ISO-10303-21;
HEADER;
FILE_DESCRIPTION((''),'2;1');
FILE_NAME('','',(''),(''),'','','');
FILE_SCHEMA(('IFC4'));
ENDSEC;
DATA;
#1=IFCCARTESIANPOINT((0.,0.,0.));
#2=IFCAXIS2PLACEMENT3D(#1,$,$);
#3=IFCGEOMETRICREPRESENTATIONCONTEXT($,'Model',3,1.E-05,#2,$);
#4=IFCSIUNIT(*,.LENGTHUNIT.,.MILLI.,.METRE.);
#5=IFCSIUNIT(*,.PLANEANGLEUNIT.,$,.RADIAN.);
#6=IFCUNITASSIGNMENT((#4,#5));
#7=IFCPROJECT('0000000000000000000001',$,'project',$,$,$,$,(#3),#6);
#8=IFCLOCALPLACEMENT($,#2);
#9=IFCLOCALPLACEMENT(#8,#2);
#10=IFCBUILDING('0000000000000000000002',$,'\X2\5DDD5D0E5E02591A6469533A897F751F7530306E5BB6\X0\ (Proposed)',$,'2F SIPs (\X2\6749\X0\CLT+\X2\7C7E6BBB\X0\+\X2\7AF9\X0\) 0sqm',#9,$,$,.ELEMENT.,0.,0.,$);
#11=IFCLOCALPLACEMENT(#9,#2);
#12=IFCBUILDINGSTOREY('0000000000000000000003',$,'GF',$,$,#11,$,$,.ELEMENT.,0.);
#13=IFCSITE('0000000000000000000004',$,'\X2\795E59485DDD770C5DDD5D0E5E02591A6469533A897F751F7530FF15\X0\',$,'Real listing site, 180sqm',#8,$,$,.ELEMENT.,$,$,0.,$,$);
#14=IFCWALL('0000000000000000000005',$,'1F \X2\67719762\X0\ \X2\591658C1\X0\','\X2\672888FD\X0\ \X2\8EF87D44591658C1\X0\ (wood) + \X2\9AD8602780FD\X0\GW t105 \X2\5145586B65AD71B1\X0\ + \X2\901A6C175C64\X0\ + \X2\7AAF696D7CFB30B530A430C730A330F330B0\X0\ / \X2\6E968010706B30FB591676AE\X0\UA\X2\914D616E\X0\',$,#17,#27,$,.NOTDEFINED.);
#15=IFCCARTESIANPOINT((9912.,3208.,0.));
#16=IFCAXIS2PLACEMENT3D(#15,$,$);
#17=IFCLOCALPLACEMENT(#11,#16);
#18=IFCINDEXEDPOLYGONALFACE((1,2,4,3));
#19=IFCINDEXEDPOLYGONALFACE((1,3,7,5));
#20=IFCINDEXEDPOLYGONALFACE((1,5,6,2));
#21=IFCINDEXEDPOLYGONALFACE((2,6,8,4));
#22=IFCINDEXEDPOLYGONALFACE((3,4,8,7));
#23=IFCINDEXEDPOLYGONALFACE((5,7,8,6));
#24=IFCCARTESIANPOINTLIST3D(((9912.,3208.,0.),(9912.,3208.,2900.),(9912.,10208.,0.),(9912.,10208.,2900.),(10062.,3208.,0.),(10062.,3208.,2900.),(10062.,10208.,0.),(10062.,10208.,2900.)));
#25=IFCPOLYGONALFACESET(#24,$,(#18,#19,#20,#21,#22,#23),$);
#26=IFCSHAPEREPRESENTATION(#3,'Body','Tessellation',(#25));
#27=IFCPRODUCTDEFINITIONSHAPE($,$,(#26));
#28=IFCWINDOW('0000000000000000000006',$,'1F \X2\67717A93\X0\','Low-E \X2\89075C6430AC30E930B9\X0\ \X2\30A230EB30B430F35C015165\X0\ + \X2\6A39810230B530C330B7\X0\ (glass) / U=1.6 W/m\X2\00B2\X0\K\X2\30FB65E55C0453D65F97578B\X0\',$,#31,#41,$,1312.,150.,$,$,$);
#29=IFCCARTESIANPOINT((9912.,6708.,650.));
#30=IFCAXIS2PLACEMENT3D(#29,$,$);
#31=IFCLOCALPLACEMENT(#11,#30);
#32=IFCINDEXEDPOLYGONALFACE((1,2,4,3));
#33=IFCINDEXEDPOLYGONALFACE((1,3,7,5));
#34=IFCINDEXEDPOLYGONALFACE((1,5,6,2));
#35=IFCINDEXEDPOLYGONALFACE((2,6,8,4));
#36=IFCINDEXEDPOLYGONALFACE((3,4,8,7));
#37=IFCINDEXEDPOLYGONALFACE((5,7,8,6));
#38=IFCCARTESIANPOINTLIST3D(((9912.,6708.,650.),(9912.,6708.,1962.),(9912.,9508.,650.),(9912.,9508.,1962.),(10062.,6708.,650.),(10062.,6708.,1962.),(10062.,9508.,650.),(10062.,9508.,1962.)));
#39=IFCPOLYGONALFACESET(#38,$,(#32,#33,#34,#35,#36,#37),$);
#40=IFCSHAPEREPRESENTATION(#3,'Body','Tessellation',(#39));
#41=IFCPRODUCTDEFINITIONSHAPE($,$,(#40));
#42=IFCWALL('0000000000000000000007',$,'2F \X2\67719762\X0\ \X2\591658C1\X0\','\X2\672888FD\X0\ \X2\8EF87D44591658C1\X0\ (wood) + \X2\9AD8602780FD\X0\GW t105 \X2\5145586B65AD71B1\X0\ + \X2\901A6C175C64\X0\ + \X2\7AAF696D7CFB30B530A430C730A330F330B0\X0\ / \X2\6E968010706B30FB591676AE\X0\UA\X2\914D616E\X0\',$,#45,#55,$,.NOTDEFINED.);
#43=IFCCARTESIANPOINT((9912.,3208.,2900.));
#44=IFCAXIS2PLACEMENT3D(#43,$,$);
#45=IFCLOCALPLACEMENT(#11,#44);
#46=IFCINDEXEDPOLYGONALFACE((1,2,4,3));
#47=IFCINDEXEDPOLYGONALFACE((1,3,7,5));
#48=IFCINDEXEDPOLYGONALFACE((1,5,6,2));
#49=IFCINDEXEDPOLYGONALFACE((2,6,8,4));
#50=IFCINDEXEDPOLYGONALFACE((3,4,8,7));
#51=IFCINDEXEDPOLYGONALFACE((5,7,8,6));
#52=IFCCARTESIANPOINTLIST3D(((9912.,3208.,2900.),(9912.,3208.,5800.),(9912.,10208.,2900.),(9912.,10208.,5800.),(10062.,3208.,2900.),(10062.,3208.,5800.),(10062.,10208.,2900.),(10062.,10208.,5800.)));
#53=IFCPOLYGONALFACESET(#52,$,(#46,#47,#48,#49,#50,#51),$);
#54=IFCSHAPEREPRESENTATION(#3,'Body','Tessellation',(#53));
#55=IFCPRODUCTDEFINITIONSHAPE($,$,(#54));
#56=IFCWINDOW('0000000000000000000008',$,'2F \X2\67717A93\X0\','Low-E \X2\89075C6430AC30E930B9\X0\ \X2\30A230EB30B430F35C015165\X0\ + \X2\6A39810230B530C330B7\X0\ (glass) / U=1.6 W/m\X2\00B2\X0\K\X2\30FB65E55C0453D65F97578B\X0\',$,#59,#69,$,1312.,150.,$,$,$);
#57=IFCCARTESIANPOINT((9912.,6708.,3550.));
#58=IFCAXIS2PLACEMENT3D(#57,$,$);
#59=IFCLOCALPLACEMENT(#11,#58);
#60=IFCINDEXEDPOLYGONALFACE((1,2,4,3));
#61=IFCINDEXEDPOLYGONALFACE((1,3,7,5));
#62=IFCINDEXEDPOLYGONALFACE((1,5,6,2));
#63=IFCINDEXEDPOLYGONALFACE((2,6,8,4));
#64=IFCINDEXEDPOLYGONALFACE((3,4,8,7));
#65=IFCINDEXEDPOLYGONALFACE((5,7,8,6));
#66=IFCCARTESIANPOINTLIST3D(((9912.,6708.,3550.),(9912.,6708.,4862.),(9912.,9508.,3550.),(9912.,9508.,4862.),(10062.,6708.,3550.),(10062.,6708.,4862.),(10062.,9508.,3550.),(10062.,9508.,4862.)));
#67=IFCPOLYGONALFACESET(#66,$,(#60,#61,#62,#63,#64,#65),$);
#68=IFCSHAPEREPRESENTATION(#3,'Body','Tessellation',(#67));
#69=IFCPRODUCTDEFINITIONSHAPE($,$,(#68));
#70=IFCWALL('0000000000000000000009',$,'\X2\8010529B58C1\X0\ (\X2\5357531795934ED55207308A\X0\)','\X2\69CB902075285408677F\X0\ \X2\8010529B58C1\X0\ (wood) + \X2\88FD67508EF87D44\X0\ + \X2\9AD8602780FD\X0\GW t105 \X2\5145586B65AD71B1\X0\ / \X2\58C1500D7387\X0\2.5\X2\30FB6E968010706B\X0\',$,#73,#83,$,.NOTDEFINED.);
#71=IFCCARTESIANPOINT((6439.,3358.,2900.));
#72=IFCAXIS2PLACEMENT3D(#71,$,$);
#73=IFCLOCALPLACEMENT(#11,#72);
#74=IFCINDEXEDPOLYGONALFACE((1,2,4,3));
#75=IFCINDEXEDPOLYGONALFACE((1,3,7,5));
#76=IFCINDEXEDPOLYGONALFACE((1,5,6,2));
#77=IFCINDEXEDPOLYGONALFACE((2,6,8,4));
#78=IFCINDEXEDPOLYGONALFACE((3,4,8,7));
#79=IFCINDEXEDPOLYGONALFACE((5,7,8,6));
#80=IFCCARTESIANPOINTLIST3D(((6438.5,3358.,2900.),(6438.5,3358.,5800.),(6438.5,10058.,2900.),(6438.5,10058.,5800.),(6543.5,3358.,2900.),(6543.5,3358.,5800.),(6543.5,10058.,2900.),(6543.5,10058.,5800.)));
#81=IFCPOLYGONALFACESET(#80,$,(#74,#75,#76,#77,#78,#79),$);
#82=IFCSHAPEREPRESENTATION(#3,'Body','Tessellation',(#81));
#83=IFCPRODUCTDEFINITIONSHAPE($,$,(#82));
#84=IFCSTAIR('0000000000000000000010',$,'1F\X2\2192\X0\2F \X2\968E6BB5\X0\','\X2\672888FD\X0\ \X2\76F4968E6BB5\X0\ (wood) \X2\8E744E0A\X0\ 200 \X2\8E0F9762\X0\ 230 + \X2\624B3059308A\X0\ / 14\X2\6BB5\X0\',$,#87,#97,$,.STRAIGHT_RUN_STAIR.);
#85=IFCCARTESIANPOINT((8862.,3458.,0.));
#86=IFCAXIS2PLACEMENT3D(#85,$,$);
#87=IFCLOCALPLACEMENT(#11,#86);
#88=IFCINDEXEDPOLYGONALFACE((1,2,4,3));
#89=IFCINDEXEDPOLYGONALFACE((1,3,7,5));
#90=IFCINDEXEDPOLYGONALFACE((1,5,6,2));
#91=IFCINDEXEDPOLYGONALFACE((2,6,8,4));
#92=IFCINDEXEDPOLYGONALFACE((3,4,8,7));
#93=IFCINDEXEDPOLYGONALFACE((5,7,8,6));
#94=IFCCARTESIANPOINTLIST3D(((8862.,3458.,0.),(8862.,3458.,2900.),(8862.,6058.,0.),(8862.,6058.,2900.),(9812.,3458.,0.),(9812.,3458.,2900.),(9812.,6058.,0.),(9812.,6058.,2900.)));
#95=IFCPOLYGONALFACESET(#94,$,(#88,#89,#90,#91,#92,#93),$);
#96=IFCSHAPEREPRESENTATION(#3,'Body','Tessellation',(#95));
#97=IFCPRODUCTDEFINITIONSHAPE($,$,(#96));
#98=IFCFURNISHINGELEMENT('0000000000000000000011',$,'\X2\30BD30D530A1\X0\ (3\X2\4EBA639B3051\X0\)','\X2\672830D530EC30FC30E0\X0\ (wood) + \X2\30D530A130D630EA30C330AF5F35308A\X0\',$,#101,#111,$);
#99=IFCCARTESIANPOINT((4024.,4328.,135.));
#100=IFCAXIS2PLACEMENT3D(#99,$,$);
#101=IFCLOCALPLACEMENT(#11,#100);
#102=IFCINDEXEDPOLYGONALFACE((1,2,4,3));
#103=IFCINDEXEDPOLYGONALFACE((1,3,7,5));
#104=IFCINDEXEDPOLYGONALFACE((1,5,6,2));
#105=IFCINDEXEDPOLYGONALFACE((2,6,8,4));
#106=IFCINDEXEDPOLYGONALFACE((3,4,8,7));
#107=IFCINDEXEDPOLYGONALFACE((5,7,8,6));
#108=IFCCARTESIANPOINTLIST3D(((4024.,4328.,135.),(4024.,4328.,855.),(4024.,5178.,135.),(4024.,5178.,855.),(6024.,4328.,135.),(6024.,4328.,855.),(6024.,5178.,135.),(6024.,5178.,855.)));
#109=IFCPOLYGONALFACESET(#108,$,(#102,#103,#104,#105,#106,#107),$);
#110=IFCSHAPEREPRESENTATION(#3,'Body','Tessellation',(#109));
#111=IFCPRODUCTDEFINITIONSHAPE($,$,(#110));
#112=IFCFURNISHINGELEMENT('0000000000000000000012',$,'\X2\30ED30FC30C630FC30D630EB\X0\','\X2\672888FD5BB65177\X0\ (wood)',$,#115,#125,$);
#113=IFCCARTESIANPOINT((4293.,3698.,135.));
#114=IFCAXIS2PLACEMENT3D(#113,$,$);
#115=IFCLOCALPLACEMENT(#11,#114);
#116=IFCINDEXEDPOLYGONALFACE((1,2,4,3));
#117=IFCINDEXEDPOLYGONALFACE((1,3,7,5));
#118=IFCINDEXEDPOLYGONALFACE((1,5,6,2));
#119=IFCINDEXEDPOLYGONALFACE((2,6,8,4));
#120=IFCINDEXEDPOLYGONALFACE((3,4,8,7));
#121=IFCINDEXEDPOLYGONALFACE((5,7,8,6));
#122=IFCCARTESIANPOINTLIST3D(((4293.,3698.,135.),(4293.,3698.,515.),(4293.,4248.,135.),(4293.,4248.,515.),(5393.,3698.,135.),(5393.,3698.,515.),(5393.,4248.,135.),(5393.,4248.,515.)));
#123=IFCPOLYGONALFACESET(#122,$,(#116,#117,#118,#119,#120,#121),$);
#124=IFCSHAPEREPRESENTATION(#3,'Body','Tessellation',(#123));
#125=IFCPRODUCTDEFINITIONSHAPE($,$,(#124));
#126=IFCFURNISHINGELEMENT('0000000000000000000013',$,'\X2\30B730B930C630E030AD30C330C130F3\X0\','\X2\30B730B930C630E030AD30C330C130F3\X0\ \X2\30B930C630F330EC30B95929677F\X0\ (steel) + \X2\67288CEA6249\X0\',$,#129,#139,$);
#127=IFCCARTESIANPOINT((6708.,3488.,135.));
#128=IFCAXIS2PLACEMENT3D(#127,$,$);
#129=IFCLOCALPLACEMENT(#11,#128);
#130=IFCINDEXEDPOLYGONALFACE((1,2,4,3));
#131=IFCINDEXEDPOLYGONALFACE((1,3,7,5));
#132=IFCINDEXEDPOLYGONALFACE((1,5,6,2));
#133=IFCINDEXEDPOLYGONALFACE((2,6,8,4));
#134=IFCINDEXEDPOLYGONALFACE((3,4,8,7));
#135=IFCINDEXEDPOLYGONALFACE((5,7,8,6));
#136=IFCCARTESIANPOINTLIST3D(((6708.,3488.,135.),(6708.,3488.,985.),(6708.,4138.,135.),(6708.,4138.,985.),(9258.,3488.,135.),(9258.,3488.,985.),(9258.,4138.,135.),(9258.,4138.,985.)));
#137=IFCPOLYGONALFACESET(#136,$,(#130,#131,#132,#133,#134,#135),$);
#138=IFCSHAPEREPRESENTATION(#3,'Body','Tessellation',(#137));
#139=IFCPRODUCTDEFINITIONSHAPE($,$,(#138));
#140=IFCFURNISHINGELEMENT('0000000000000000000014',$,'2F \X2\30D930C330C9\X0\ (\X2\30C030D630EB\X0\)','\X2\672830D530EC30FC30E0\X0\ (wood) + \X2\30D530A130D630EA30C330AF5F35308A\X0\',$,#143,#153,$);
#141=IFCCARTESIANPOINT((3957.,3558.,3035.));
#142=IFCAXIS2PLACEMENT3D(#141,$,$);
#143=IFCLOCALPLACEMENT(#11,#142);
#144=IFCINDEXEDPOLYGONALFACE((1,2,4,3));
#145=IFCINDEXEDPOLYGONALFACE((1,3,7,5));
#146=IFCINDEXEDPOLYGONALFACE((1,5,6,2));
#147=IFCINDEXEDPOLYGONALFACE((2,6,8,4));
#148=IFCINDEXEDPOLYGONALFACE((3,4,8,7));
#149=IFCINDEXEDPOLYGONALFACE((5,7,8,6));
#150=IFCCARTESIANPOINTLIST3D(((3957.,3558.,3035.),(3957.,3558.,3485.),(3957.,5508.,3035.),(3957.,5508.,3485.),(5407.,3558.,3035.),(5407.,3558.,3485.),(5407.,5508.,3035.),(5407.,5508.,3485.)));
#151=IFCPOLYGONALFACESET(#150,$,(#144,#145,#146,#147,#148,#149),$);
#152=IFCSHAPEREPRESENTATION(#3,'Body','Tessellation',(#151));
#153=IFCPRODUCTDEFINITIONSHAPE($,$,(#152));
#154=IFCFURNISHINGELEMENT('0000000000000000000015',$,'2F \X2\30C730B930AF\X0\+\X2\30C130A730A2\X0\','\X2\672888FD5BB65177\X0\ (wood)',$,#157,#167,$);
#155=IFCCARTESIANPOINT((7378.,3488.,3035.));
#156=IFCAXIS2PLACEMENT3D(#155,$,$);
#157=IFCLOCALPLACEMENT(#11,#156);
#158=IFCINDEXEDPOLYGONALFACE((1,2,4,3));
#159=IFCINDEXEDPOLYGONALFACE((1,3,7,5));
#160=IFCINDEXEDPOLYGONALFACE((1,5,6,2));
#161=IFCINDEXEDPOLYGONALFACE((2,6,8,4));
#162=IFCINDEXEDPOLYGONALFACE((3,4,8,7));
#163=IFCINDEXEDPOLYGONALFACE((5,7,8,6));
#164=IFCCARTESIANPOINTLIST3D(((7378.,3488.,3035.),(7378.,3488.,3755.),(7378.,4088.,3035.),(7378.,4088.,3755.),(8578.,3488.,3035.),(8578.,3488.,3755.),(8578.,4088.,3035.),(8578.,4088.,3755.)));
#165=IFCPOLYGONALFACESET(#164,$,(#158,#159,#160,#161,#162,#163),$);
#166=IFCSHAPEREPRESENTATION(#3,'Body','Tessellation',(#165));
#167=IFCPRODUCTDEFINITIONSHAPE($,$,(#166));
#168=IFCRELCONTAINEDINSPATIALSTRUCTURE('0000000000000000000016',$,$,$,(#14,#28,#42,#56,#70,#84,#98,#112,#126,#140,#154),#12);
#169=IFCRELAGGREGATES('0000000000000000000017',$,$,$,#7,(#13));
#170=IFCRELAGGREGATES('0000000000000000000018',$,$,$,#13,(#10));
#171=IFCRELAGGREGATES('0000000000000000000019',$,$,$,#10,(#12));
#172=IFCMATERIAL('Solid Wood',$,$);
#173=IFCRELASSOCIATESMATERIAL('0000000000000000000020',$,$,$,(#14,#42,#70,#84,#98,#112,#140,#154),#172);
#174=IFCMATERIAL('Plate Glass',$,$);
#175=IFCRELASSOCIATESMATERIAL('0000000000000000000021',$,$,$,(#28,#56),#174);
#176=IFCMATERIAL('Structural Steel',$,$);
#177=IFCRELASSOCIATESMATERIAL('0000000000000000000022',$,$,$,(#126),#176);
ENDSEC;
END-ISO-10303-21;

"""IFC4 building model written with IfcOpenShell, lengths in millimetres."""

from ifc_helpers import new_model, si_unit, frame, frame_2d, origin, place, context, project, spatial, rectangle, extrude, material, element, fill, save


model = new_model("IFC4")

# Units and contexts
model_context = context("Model", 3, precision=1e-05, world=origin())
ifc_project = project(units=[si_unit("LENGTHUNIT", "METRE", prefix="MILLI"), si_unit("PLANEANGLEUNIT", "RADIAN")], contexts=[model_context])

# Site, building, storey
site_placement = place(None, origin())
site = spatial("IfcSite", under=ifc_project, at=site_placement, Name="神奈川県川崎市多摩区西生田５", ObjectType="Real listing site, 180sqm", CompositionType="ELEMENT", RefElevation=0.0)
building_placement = place(site_placement, origin())
building = spatial("IfcBuilding", under=site, at=building_placement, Name="川崎市多摩区西生田の家 (Proposed)", ObjectType="2F SIPs (杉CLT+籾殻+竹) 0sqm", CompositionType="ELEMENT", ElevationOfRefHeight=0.0, ElevationOfTerrain=0.0)
storey_placement = place(building_placement, origin())
storey = spatial("IfcBuildingStorey", under=building, at=storey_placement, Name="GF", CompositionType="ELEMENT", Elevation=0.0)

# Wall, opening, window
ifc_material_1 = material(Name="Solid Wood")
wall_1_placement = place(storey_placement, frame((9912.0, 3208.0, 0.0)))
wall_1 = element("IfcWall", 1, at=wall_1_placement, inside=storey, material=ifc_material_1, Name="1F 東面 外壁", Description="木製 軸組外壁 (wood) + 高性能GW t105 充填断熱 + 通気層 + 窯業系サイディング / 準耐火・外皮UA配慮", PredefinedType="NOTDEFINED", context=model_context, shape_type="SweptSolid", body=[
    extrude(rectangle(XDim=150.0, YDim=7000.0, at=frame_2d((75.0, 3500.0))), frame((9912.0, 3208.0, 0.0)), (0.0, 0.0, 1.0), 2900.0),
])
opening_1_placement = place(storey_placement, frame((9912.0, 6708.0, 650.0)))
opening_1 = element("IfcOpeningElement", 2, at=opening_1_placement, cuts=wall_1, PredefinedType="NOTDEFINED", context=model_context, shape_type="SweptSolid", body=[
    extrude(rectangle(XDim=150.0, YDim=2800.0, at=frame_2d((75.0, 1400.0))), frame((9912.0, 6708.0, 650.0)), (0.0, 0.0, 1.0), 1312.0),
])
ifc_material_2 = material(Name="Plate Glass")
window_1_placement = place(storey_placement, frame((9912.0, 6708.0, 650.0)))
window_1 = element("IfcWindow", 3, at=window_1_placement, inside=storey, material=ifc_material_2, Name="1F 東窓", Description="Low-E 複層ガラス アルゴン封入 + 樹脂サッシ (glass) / U=1.6 W/m²K・日射取得型", OverallHeight=1312.0, OverallWidth=150.0, context=model_context, shape_type="SweptSolid", body=[
    extrude(rectangle(XDim=150.0, YDim=2800.0, at=frame_2d((75.0, 1400.0))), frame((9912.0, 6708.0, 650.0)), (0.0, 0.0, 1.0), 1312.0),
])
fill(opening_1, window_1)

# Wall, opening, window
wall_2_placement = place(storey_placement, frame((9912.0, 3208.0, 2900.0)))
wall_2 = element("IfcWall", 4, at=wall_2_placement, inside=storey, material=ifc_material_1, Name="2F 東面 外壁", Description="木製 軸組外壁 (wood) + 高性能GW t105 充填断熱 + 通気層 + 窯業系サイディング / 準耐火・外皮UA配慮", PredefinedType="NOTDEFINED", context=model_context, shape_type="SweptSolid", body=[
    extrude(rectangle(XDim=150.0, YDim=7000.0, at=frame_2d((75.0, 3500.0))), frame((9912.0, 3208.0, 2900.0)), (0.0, 0.0, 1.0), 2900.0),
])
opening_2_placement = place(storey_placement, frame((9912.0, 6708.0, 3550.0)))
opening_2 = element("IfcOpeningElement", 5, at=opening_2_placement, cuts=wall_2, PredefinedType="NOTDEFINED", context=model_context, shape_type="SweptSolid", body=[
    extrude(rectangle(XDim=150.0, YDim=2800.0, at=frame_2d((75.0, 1400.0))), frame((9912.0, 6708.0, 3550.0)), (0.0, 0.0, 1.0), 1312.0),
])
window_2_placement = place(storey_placement, frame((9912.0, 6708.0, 3550.0)))
window_2 = element("IfcWindow", 6, at=window_2_placement, inside=storey, material=ifc_material_2, Name="2F 東窓", Description="Low-E 複層ガラス アルゴン封入 + 樹脂サッシ (glass) / U=1.6 W/m²K・日射取得型", OverallHeight=1312.0, OverallWidth=150.0, context=model_context, shape_type="SweptSolid", body=[
    extrude(rectangle(XDim=150.0, YDim=2800.0, at=frame_2d((75.0, 1400.0))), frame((9912.0, 6708.0, 3550.0)), (0.0, 0.0, 1.0), 1312.0),
])
fill(opening_2, window_2)

# Wall
wall_3_placement = place(storey_placement, frame((6439.0, 3358.0, 2900.0)))
element("IfcWall", 7, at=wall_3_placement, inside=storey, material=ifc_material_1, Name="耐力壁 (南北間仕切り)", Description="構造用合板 耐力壁 (wood) + 製材軸組 + 高性能GW t105 充填断熱 / 壁倍率2.5・準耐火", PredefinedType="NOTDEFINED", context=model_context, shape_type="SweptSolid", body=[
    extrude(rectangle(XDim=105.0, YDim=6700.0, at=frame_2d((52.0, 3350.0))), frame((6439.0, 3358.0, 2900.0)), (0.0, 0.0, 1.0), 2900.0),
])

# Stair
stair_placement = place(storey_placement, frame((8862.0, 3458.0, 0.0)))
element("IfcStair", 8, at=stair_placement, inside=storey, material=ifc_material_1, Name="1F→2F 階段", Description="木製 直階段 (wood) 蹴上 200 踏面 230 + 手すり / 14段", PredefinedType="STRAIGHT_RUN_STAIR", context=model_context, shape_type="SweptSolid", body=[
    extrude(rectangle(XDim=950.0, YDim=2600.0, at=frame_2d((475.0, 1300.0))), frame((8862.0, 3458.0, 0.0)), (0.0, 0.0, 1.0), 2900.0),
])

# Furnishing elements
furnishing_1_placement = place(storey_placement, frame((4024.0, 4328.0, 135.0)))
element("IfcFurnishingElement", 9, at=furnishing_1_placement, inside=storey, material=ifc_material_1, Name="ソファ (3人掛け)", Description="木フレーム (wood) + ファブリック張り", context=model_context, shape_type="SweptSolid", body=[
    extrude(rectangle(XDim=2000.0, YDim=850.0, at=frame_2d((1000.0, 425.0))), frame((4024.0, 4328.0, 135.0)), (0.0, 0.0, 1.0), 720.0),
])
furnishing_2_placement = place(storey_placement, frame((4293.0, 3698.0, 135.0)))
element("IfcFurnishingElement", 10, at=furnishing_2_placement, inside=storey, material=ifc_material_1, Name="ローテーブル", Description="木製家具 (wood)", context=model_context, shape_type="SweptSolid", body=[
    extrude(rectangle(XDim=1100.0, YDim=550.0, at=frame_2d((550.0, 275.0))), frame((4293.0, 3698.0, 135.0)), (0.0, 0.0, 1.0), 380.0),
])
ifc_material_3 = material(Name="Structural Steel")
furnishing_3_placement = place(storey_placement, frame((6708.0, 3488.0, 135.0)))
element("IfcFurnishingElement", 11, at=furnishing_3_placement, inside=storey, material=ifc_material_3, Name="システムキッチン", Description="システムキッチン ステンレス天板 (steel) + 木質扉", context=model_context, shape_type="SweptSolid", body=[
    extrude(rectangle(XDim=2550.0, YDim=650.0, at=frame_2d((1275.0, 325.0))), frame((6708.0, 3488.0, 135.0)), (0.0, 0.0, 1.0), 850.0),
])
furnishing_4_placement = place(storey_placement, frame((3957.0, 3558.0, 3035.0)))
element("IfcFurnishingElement", 12, at=furnishing_4_placement, inside=storey, material=ifc_material_1, Name="2F ベッド (ダブル)", Description="木フレーム (wood) + ファブリック張り", context=model_context, shape_type="SweptSolid", body=[
    extrude(rectangle(XDim=1450.0, YDim=1950.0, at=frame_2d((725.0, 975.0))), frame((3957.0, 3558.0, 3035.0)), (0.0, 0.0, 1.0), 450.0),
])
furnishing_5_placement = place(storey_placement, frame((7378.0, 3488.0, 3035.0)))
element("IfcFurnishingElement", 13, at=furnishing_5_placement, inside=storey, material=ifc_material_1, Name="2F デスク+チェア", Description="木製家具 (wood)", context=model_context, shape_type="SweptSolid", body=[
    extrude(rectangle(XDim=1200.0, YDim=600.0, at=frame_2d((600.0, 300.0))), frame((7378.0, 3488.0, 3035.0)), (0.0, 0.0, 1.0), 720.0),
])

save(model, "model.ifc")
